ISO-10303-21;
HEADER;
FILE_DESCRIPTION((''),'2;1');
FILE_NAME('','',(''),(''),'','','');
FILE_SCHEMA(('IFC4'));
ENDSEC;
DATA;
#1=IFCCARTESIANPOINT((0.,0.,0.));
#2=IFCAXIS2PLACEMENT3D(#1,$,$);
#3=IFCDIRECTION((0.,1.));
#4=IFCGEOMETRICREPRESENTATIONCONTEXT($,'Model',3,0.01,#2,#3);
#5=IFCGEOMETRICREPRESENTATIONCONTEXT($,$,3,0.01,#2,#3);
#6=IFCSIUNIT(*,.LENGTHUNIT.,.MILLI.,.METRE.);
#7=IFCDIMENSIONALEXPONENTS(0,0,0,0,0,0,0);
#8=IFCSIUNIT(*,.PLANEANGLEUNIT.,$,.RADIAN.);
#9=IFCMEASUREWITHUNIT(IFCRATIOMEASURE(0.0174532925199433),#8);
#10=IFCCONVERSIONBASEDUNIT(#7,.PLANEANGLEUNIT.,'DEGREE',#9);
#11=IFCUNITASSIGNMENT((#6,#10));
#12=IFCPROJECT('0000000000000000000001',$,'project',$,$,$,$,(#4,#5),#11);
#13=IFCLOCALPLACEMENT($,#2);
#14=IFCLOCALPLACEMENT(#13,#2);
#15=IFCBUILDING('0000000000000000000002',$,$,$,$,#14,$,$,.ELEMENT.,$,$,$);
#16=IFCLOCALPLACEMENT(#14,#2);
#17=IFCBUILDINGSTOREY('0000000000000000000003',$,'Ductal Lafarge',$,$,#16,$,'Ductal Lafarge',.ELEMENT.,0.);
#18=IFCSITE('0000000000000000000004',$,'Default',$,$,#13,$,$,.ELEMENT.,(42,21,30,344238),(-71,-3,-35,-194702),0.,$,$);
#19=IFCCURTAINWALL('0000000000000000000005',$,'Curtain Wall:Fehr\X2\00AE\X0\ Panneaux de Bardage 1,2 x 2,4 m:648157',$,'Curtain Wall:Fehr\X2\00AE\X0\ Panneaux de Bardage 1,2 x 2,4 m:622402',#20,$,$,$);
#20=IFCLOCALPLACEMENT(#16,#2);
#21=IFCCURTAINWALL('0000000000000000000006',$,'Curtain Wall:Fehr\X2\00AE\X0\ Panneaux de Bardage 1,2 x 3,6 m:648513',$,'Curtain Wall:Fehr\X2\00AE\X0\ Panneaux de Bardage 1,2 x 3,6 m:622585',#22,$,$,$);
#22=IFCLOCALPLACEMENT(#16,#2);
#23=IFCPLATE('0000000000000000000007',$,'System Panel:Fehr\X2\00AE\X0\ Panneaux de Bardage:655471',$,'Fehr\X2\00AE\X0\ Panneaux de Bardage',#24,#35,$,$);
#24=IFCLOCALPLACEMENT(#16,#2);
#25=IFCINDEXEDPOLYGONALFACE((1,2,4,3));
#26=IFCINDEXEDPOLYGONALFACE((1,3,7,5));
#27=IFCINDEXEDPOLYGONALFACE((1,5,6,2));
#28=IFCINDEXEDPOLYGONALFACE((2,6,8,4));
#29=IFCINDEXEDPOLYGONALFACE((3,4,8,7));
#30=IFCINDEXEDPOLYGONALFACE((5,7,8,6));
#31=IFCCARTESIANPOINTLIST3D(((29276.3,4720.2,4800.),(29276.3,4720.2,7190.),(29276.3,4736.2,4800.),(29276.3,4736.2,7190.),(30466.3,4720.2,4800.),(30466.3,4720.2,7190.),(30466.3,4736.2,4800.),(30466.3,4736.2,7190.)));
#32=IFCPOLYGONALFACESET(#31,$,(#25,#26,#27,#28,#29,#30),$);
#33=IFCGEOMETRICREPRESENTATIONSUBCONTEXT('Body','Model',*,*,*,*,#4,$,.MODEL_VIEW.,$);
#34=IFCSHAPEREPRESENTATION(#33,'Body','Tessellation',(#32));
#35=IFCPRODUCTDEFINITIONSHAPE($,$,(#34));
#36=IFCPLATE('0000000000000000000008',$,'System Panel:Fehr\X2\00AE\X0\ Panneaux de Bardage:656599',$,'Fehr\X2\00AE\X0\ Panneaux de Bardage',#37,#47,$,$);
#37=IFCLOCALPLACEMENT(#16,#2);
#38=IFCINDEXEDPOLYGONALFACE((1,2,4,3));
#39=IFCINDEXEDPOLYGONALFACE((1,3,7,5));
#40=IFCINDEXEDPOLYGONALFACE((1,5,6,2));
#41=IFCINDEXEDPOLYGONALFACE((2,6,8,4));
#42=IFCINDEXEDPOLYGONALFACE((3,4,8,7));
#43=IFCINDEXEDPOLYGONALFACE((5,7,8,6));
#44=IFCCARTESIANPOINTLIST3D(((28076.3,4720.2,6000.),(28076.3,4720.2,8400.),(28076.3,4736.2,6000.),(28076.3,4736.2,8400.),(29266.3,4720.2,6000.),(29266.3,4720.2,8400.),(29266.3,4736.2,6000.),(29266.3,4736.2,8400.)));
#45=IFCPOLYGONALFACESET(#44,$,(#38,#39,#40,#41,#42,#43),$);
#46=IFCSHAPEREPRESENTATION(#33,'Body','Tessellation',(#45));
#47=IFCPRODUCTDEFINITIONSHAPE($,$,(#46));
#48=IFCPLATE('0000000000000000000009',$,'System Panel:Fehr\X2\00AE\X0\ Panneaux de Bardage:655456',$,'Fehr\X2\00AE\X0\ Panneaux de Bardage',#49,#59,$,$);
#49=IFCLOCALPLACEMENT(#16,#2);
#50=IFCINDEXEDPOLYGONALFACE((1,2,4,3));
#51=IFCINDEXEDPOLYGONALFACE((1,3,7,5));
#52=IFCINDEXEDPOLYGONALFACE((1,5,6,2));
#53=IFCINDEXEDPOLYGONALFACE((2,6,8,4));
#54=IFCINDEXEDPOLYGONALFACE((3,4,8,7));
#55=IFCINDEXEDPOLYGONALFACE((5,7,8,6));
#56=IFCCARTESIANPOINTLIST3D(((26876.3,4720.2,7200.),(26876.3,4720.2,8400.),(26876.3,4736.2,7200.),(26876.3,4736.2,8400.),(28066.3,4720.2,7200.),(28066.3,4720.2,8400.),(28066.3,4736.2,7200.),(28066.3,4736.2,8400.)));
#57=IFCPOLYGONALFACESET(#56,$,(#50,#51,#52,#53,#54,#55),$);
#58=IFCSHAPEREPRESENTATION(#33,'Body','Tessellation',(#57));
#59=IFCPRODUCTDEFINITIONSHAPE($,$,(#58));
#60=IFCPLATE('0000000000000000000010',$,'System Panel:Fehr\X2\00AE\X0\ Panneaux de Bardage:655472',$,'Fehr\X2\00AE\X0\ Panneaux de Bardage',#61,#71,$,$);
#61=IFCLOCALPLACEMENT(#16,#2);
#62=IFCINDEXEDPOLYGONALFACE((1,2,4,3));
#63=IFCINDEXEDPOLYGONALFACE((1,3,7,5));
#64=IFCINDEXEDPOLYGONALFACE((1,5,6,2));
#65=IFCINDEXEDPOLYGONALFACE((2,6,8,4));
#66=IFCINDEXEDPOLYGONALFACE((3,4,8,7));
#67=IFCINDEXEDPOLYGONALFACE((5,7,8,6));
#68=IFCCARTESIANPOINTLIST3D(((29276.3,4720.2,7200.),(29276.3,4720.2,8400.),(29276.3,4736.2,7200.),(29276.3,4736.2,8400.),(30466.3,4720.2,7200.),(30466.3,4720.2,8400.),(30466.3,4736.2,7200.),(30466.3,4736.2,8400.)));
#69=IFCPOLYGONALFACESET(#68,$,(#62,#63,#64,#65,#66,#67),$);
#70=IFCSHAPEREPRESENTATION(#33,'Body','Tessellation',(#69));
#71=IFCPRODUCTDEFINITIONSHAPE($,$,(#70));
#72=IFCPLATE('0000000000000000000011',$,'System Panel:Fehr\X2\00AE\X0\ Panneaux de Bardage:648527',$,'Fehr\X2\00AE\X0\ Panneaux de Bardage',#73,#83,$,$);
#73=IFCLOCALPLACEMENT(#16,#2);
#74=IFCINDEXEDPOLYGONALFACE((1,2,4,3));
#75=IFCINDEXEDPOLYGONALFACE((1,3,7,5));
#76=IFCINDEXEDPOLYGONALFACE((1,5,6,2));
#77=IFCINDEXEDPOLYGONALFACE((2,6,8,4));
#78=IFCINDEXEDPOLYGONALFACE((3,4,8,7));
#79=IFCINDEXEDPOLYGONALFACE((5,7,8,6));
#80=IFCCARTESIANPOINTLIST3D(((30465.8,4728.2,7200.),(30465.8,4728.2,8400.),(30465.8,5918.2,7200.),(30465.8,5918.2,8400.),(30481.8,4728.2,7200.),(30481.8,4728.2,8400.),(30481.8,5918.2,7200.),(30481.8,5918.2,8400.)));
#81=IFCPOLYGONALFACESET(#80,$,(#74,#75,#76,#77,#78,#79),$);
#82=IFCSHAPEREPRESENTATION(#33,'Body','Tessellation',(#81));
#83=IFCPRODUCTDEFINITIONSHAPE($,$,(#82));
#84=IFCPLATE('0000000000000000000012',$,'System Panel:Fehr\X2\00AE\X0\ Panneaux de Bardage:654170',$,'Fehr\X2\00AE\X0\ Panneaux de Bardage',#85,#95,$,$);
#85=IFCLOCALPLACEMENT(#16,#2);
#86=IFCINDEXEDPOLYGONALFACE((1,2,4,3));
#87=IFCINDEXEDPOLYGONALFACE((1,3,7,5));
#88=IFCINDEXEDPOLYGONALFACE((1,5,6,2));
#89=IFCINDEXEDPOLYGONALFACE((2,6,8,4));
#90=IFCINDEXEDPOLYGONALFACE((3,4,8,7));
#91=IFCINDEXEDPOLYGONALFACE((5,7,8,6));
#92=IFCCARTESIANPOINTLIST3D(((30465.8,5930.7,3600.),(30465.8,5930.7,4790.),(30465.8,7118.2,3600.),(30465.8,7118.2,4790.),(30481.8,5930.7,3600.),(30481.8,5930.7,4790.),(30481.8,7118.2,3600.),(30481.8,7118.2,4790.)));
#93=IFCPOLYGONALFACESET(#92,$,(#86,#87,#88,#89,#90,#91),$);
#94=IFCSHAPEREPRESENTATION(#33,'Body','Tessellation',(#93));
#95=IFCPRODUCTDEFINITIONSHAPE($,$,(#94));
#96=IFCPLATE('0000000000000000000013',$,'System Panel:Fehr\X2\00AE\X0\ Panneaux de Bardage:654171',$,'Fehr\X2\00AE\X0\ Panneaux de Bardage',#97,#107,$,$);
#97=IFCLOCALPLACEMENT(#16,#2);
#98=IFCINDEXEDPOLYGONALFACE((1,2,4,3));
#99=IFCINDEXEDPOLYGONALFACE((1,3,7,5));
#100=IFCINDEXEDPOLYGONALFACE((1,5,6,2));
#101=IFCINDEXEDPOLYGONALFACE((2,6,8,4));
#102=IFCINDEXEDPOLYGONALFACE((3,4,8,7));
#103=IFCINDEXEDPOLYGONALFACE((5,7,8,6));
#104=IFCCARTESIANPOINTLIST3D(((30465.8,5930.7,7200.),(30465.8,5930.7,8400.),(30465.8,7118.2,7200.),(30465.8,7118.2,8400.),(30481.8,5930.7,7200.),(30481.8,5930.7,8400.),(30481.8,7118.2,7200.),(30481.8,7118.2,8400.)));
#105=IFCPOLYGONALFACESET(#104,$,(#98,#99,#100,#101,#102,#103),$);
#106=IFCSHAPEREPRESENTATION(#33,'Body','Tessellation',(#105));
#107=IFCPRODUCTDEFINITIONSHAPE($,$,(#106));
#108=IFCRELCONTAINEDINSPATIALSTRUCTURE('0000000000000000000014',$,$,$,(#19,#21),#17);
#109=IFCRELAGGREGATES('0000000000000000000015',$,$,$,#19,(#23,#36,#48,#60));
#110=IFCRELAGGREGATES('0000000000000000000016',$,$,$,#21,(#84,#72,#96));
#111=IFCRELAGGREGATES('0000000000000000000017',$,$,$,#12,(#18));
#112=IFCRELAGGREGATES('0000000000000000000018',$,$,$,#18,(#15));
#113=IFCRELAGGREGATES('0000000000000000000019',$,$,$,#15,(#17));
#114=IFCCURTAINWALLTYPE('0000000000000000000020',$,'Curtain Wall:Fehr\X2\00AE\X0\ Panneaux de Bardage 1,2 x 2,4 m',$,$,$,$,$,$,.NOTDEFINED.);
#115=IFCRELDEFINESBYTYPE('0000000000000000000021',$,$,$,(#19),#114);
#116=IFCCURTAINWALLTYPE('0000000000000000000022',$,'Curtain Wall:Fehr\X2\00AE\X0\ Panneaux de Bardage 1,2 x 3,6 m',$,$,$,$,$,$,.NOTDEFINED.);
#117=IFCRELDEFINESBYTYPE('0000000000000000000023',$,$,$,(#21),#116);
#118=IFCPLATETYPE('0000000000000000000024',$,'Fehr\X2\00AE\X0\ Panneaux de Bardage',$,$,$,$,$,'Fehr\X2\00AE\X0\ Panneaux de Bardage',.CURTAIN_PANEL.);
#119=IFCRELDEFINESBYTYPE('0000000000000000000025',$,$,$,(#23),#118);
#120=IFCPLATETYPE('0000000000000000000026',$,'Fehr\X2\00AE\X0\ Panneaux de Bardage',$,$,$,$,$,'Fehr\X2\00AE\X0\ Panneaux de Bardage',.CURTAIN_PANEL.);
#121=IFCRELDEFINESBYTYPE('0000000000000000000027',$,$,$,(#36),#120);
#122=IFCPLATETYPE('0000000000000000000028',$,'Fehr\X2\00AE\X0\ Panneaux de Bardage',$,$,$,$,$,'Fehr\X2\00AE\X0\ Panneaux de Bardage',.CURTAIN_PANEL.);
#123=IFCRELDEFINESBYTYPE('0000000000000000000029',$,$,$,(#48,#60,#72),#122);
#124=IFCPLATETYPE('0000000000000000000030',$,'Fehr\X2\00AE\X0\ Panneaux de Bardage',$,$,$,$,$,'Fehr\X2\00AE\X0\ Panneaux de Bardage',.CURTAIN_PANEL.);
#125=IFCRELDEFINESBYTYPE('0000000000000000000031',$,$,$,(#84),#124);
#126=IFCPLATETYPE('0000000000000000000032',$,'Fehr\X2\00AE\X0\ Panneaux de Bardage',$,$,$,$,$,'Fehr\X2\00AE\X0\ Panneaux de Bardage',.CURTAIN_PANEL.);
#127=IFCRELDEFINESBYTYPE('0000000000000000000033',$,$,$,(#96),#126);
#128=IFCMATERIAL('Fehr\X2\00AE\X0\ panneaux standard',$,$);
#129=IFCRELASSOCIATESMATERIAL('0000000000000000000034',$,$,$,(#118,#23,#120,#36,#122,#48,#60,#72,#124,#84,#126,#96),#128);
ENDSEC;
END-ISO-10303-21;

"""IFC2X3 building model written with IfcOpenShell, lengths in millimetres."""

from ifc_helpers import new_model, entity, si_unit, converted_unit, direction, frame, frame_2d, origin, origin_2d_with_axis, place, context, subcontext, project, spatial, rectangle, extrude, source, transform, mapped, material, type_object, type_shapes, element, aggregate, save


model = new_model("IFC2X3")

# Units and contexts
model_context = context("Model", 3, precision=0.01, world=origin(), true_north=direction((0.0, 1.0)))
context_of_model = context(None, 3, precision=0.01, world=origin(), true_north=direction((0.0, 1.0)))
body_context = subcontext(model_context, "Body", "Model", "MODEL_VIEW")
ifc_project = project(units=[si_unit("LENGTHUNIT", "METRE", prefix="MILLI"), converted_unit("PLANEANGLEUNIT", "DEGREE", entity("IfcRatioMeasure", 0.0174532925199433), si_unit("PLANEANGLEUNIT", "RADIAN"), dimensions=[0, 0, 0, 0, 0, 0, 0])], contexts=[model_context, context_of_model])

# Site, building, storey
site_placement = place(None, origin())
site = spatial("IfcSite", under=ifc_project, at=site_placement, Name="Default", CompositionType="ELEMENT", RefLatitude=(42, 21, 30, 344238), RefLongitude=(-71, -3, -35, -194702), RefElevation=0.0)
building_placement = place(site_placement, origin())
building = spatial("IfcBuilding", under=site, at=building_placement, CompositionType="ELEMENT")
storey_placement = place(building_placement, origin())
storey = spatial("IfcBuildingStorey", under=building, at=storey_placement, Name="Ductal Lafarge", LongName="Ductal Lafarge", CompositionType="ELEMENT", Elevation=0.0)

# Curtain walls
curtain_wall_type_1 = type_object("IfcCurtainWallType", Name="Curtain Wall:Fehr® Panneaux de Bardage 1,2 x 2,4 m", PredefinedType="NOTDEFINED")
curtain_wall_1_placement = place(storey_placement, origin())
curtain_wall_1 = element("IfcCurtainWall", 1, at=curtain_wall_1_placement, inside=storey, type_object=curtain_wall_type_1, Name="Curtain Wall:Fehr® Panneaux de Bardage 1,2 x 2,4 m:648157", ObjectType="Curtain Wall:Fehr® Panneaux de Bardage 1,2 x 2,4 m:622402")
curtain_wall_type_2 = type_object("IfcCurtainWallType", Name="Curtain Wall:Fehr® Panneaux de Bardage 1,2 x 3,6 m", PredefinedType="NOTDEFINED")
curtain_wall_2_placement = place(storey_placement, origin())
curtain_wall_2 = element("IfcCurtainWall", 2, at=curtain_wall_2_placement, inside=storey, type_object=curtain_wall_type_2, Name="Curtain Wall:Fehr® Panneaux de Bardage 1,2 x 3,6 m:648513", ObjectType="Curtain Wall:Fehr® Panneaux de Bardage 1,2 x 3,6 m:622585")

# Plates
ifc_material_1 = material(Name="Fehr® panneaux standard")
plate_type_1 = type_object("IfcPlateType", Name="Fehr® Panneaux de Bardage", ElementType="Fehr® Panneaux de Bardage", PredefinedType="CURTAIN_PANEL", material=ifc_material_1)
shared_shape_1 = source(origin(), body_context, "Body", "SweptSolid", [
    extrude(rectangle(XDim=2390.0, YDim=1190.0, at=origin_2d_with_axis()), frame((0.0, -8.0, 1195.0), z_axis=(0.0, 1.0, 0.0), x_axis=(0.0, 0.0, 1.0)), (0.0, 0.0, 1.0), 16.0),
])
type_shapes(plate_type_1, [shared_shape_1])
plate_1_placement = place(curtain_wall_1_placement, frame((29871.3, 4728.2, 4800.0)))
plate_1 = element("IfcPlate", 3, at=plate_1_placement, type_object=plate_type_1, material=ifc_material_1, Name="System Panel:Fehr® Panneaux de Bardage:655471", ObjectType="Fehr® Panneaux de Bardage", context=body_context, shape_type="MappedRepresentation", body=[
    mapped(shared_shape_1, transform((0.0, 0.0, 0.0), scale=1.0)),
])
plate_type_2 = type_object("IfcPlateType", Name="Fehr® Panneaux de Bardage", ElementType="Fehr® Panneaux de Bardage", PredefinedType="CURTAIN_PANEL", material=ifc_material_1)
shared_shape_2 = source(origin(), body_context, "Body", "SweptSolid", [
    extrude(rectangle(XDim=2400.0, YDim=1190.0, at=frame_2d((1.7, 0.0), x_axis=(1.0, 0.0))), frame((0.0, -8.0, 1198.3), z_axis=(0.0, 1.0, 0.0), x_axis=(0.0, 0.0, 1.0)), (0.0, 0.0, 1.0), 16.0),
])
type_shapes(plate_type_2, [shared_shape_2])
plate_2_placement = place(curtain_wall_1_placement, frame((28671.3, 4728.2, 6000.0)))
plate_2 = element("IfcPlate", 4, at=plate_2_placement, type_object=plate_type_2, material=ifc_material_1, Name="System Panel:Fehr® Panneaux de Bardage:656599", ObjectType="Fehr® Panneaux de Bardage", context=body_context, shape_type="MappedRepresentation", body=[
    mapped(shared_shape_2, transform((0.0, 0.0, 0.0), scale=1.0)),
])
plate_type_3 = type_object("IfcPlateType", Name="Fehr® Panneaux de Bardage", ElementType="Fehr® Panneaux de Bardage", PredefinedType="CURTAIN_PANEL", material=ifc_material_1)
shared_shape_3 = source(origin(), body_context, "Body", "SweptSolid", [
    extrude(rectangle(XDim=16.0, YDim=1190.0, at=origin_2d_with_axis()), frame((0.0, 0.0, 0.0), z_axis=(0.0, 0.0, 1.0), x_axis=(0.0, 1.0, 0.0)), (0.0, 0.0, 1.0), 1200.0),
])
type_shapes(plate_type_3, [shared_shape_3])
plate_3_placement = place(curtain_wall_1_placement, frame((27471.3, 4728.2, 7200.0)))
plate_3 = element("IfcPlate", 5, at=plate_3_placement, type_object=plate_type_3, material=ifc_material_1, Name="System Panel:Fehr® Panneaux de Bardage:655456", ObjectType="Fehr® Panneaux de Bardage", context=body_context, shape_type="MappedRepresentation", body=[
    mapped(shared_shape_3, transform((0.0, 0.0, 0.0), scale=1.0)),
])
plate_4_placement = place(curtain_wall_1_placement, frame((29871.3, 4728.2, 7200.0)))
plate_4 = element("IfcPlate", 6, at=plate_4_placement, type_object=plate_type_3, material=ifc_material_1, Name="System Panel:Fehr® Panneaux de Bardage:655472", ObjectType="Fehr® Panneaux de Bardage", context=body_context, shape_type="MappedRepresentation", body=[
    mapped(shared_shape_3, transform((0.0, 0.0, 0.0), scale=1.0)),
])
aggregate(curtain_wall_1, [plate_1, plate_2, plate_3, plate_4])
plate_5_placement = place(curtain_wall_2_placement, frame((30473.8, 5323.2, 7200.0), z_axis=(0.0, 0.0, 1.0), x_axis=(0.0, 1.0, 0.0)))
plate_5 = element("IfcPlate", 7, at=plate_5_placement, type_object=plate_type_3, material=ifc_material_1, Name="System Panel:Fehr® Panneaux de Bardage:648527", ObjectType="Fehr® Panneaux de Bardage", context=body_context, shape_type="MappedRepresentation", body=[
    mapped(shared_shape_3, transform((0.0, 0.0, 0.0), scale=1.0)),
])
plate_type_4 = type_object("IfcPlateType", Name="Fehr® Panneaux de Bardage", ElementType="Fehr® Panneaux de Bardage", PredefinedType="CURTAIN_PANEL", material=ifc_material_1)
shared_shape_4 = source(origin(), body_context, "Body", "SweptSolid", [
    extrude(rectangle(XDim=16.0, YDim=1187.5, at=origin_2d_with_axis()), frame((0.0, 0.0, 0.0), z_axis=(0.0, 0.0, 1.0), x_axis=(0.0, 1.0, 0.0)), (0.0, 0.0, 1.0), 1190.0),
])
type_shapes(plate_type_4, [shared_shape_4])
plate_6_placement = place(curtain_wall_2_placement, frame((30473.8, 6524.4, 3600.0), z_axis=(0.0, 0.0, 1.0), x_axis=(0.0, 1.0, 0.0)))
plate_6 = element("IfcPlate", 8, at=plate_6_placement, type_object=plate_type_4, material=ifc_material_1, Name="System Panel:Fehr® Panneaux de Bardage:654170", ObjectType="Fehr® Panneaux de Bardage", context=body_context, shape_type="MappedRepresentation", body=[
    mapped(shared_shape_4, transform((0.0, 0.0, 0.0), scale=1.0)),
])
plate_type_5 = type_object("IfcPlateType", Name="Fehr® Panneaux de Bardage", ElementType="Fehr® Panneaux de Bardage", PredefinedType="CURTAIN_PANEL", material=ifc_material_1)
shared_shape_5 = source(origin(), body_context, "Body", "SweptSolid", [
    extrude(rectangle(XDim=16.0, YDim=1187.5, at=origin_2d_with_axis()), frame((0.0, 0.0, 0.0), z_axis=(0.0, 0.0, 1.0), x_axis=(0.0, 1.0, 0.0)), (0.0, 0.0, 1.0), 1200.0),
])
type_shapes(plate_type_5, [shared_shape_5])
plate_7_placement = place(curtain_wall_2_placement, frame((30473.8, 6524.4, 7200.0), z_axis=(0.0, 0.0, 1.0), x_axis=(0.0, 1.0, 0.0)))
plate_7 = element("IfcPlate", 9, at=plate_7_placement, type_object=plate_type_5, material=ifc_material_1, Name="System Panel:Fehr® Panneaux de Bardage:654171", ObjectType="Fehr® Panneaux de Bardage", context=body_context, shape_type="MappedRepresentation", body=[
    mapped(shared_shape_5, transform((0.0, 0.0, 0.0), scale=1.0)),
])
aggregate(curtain_wall_2, [plate_6, plate_5, plate_7])

save(model, "model.ifc")
